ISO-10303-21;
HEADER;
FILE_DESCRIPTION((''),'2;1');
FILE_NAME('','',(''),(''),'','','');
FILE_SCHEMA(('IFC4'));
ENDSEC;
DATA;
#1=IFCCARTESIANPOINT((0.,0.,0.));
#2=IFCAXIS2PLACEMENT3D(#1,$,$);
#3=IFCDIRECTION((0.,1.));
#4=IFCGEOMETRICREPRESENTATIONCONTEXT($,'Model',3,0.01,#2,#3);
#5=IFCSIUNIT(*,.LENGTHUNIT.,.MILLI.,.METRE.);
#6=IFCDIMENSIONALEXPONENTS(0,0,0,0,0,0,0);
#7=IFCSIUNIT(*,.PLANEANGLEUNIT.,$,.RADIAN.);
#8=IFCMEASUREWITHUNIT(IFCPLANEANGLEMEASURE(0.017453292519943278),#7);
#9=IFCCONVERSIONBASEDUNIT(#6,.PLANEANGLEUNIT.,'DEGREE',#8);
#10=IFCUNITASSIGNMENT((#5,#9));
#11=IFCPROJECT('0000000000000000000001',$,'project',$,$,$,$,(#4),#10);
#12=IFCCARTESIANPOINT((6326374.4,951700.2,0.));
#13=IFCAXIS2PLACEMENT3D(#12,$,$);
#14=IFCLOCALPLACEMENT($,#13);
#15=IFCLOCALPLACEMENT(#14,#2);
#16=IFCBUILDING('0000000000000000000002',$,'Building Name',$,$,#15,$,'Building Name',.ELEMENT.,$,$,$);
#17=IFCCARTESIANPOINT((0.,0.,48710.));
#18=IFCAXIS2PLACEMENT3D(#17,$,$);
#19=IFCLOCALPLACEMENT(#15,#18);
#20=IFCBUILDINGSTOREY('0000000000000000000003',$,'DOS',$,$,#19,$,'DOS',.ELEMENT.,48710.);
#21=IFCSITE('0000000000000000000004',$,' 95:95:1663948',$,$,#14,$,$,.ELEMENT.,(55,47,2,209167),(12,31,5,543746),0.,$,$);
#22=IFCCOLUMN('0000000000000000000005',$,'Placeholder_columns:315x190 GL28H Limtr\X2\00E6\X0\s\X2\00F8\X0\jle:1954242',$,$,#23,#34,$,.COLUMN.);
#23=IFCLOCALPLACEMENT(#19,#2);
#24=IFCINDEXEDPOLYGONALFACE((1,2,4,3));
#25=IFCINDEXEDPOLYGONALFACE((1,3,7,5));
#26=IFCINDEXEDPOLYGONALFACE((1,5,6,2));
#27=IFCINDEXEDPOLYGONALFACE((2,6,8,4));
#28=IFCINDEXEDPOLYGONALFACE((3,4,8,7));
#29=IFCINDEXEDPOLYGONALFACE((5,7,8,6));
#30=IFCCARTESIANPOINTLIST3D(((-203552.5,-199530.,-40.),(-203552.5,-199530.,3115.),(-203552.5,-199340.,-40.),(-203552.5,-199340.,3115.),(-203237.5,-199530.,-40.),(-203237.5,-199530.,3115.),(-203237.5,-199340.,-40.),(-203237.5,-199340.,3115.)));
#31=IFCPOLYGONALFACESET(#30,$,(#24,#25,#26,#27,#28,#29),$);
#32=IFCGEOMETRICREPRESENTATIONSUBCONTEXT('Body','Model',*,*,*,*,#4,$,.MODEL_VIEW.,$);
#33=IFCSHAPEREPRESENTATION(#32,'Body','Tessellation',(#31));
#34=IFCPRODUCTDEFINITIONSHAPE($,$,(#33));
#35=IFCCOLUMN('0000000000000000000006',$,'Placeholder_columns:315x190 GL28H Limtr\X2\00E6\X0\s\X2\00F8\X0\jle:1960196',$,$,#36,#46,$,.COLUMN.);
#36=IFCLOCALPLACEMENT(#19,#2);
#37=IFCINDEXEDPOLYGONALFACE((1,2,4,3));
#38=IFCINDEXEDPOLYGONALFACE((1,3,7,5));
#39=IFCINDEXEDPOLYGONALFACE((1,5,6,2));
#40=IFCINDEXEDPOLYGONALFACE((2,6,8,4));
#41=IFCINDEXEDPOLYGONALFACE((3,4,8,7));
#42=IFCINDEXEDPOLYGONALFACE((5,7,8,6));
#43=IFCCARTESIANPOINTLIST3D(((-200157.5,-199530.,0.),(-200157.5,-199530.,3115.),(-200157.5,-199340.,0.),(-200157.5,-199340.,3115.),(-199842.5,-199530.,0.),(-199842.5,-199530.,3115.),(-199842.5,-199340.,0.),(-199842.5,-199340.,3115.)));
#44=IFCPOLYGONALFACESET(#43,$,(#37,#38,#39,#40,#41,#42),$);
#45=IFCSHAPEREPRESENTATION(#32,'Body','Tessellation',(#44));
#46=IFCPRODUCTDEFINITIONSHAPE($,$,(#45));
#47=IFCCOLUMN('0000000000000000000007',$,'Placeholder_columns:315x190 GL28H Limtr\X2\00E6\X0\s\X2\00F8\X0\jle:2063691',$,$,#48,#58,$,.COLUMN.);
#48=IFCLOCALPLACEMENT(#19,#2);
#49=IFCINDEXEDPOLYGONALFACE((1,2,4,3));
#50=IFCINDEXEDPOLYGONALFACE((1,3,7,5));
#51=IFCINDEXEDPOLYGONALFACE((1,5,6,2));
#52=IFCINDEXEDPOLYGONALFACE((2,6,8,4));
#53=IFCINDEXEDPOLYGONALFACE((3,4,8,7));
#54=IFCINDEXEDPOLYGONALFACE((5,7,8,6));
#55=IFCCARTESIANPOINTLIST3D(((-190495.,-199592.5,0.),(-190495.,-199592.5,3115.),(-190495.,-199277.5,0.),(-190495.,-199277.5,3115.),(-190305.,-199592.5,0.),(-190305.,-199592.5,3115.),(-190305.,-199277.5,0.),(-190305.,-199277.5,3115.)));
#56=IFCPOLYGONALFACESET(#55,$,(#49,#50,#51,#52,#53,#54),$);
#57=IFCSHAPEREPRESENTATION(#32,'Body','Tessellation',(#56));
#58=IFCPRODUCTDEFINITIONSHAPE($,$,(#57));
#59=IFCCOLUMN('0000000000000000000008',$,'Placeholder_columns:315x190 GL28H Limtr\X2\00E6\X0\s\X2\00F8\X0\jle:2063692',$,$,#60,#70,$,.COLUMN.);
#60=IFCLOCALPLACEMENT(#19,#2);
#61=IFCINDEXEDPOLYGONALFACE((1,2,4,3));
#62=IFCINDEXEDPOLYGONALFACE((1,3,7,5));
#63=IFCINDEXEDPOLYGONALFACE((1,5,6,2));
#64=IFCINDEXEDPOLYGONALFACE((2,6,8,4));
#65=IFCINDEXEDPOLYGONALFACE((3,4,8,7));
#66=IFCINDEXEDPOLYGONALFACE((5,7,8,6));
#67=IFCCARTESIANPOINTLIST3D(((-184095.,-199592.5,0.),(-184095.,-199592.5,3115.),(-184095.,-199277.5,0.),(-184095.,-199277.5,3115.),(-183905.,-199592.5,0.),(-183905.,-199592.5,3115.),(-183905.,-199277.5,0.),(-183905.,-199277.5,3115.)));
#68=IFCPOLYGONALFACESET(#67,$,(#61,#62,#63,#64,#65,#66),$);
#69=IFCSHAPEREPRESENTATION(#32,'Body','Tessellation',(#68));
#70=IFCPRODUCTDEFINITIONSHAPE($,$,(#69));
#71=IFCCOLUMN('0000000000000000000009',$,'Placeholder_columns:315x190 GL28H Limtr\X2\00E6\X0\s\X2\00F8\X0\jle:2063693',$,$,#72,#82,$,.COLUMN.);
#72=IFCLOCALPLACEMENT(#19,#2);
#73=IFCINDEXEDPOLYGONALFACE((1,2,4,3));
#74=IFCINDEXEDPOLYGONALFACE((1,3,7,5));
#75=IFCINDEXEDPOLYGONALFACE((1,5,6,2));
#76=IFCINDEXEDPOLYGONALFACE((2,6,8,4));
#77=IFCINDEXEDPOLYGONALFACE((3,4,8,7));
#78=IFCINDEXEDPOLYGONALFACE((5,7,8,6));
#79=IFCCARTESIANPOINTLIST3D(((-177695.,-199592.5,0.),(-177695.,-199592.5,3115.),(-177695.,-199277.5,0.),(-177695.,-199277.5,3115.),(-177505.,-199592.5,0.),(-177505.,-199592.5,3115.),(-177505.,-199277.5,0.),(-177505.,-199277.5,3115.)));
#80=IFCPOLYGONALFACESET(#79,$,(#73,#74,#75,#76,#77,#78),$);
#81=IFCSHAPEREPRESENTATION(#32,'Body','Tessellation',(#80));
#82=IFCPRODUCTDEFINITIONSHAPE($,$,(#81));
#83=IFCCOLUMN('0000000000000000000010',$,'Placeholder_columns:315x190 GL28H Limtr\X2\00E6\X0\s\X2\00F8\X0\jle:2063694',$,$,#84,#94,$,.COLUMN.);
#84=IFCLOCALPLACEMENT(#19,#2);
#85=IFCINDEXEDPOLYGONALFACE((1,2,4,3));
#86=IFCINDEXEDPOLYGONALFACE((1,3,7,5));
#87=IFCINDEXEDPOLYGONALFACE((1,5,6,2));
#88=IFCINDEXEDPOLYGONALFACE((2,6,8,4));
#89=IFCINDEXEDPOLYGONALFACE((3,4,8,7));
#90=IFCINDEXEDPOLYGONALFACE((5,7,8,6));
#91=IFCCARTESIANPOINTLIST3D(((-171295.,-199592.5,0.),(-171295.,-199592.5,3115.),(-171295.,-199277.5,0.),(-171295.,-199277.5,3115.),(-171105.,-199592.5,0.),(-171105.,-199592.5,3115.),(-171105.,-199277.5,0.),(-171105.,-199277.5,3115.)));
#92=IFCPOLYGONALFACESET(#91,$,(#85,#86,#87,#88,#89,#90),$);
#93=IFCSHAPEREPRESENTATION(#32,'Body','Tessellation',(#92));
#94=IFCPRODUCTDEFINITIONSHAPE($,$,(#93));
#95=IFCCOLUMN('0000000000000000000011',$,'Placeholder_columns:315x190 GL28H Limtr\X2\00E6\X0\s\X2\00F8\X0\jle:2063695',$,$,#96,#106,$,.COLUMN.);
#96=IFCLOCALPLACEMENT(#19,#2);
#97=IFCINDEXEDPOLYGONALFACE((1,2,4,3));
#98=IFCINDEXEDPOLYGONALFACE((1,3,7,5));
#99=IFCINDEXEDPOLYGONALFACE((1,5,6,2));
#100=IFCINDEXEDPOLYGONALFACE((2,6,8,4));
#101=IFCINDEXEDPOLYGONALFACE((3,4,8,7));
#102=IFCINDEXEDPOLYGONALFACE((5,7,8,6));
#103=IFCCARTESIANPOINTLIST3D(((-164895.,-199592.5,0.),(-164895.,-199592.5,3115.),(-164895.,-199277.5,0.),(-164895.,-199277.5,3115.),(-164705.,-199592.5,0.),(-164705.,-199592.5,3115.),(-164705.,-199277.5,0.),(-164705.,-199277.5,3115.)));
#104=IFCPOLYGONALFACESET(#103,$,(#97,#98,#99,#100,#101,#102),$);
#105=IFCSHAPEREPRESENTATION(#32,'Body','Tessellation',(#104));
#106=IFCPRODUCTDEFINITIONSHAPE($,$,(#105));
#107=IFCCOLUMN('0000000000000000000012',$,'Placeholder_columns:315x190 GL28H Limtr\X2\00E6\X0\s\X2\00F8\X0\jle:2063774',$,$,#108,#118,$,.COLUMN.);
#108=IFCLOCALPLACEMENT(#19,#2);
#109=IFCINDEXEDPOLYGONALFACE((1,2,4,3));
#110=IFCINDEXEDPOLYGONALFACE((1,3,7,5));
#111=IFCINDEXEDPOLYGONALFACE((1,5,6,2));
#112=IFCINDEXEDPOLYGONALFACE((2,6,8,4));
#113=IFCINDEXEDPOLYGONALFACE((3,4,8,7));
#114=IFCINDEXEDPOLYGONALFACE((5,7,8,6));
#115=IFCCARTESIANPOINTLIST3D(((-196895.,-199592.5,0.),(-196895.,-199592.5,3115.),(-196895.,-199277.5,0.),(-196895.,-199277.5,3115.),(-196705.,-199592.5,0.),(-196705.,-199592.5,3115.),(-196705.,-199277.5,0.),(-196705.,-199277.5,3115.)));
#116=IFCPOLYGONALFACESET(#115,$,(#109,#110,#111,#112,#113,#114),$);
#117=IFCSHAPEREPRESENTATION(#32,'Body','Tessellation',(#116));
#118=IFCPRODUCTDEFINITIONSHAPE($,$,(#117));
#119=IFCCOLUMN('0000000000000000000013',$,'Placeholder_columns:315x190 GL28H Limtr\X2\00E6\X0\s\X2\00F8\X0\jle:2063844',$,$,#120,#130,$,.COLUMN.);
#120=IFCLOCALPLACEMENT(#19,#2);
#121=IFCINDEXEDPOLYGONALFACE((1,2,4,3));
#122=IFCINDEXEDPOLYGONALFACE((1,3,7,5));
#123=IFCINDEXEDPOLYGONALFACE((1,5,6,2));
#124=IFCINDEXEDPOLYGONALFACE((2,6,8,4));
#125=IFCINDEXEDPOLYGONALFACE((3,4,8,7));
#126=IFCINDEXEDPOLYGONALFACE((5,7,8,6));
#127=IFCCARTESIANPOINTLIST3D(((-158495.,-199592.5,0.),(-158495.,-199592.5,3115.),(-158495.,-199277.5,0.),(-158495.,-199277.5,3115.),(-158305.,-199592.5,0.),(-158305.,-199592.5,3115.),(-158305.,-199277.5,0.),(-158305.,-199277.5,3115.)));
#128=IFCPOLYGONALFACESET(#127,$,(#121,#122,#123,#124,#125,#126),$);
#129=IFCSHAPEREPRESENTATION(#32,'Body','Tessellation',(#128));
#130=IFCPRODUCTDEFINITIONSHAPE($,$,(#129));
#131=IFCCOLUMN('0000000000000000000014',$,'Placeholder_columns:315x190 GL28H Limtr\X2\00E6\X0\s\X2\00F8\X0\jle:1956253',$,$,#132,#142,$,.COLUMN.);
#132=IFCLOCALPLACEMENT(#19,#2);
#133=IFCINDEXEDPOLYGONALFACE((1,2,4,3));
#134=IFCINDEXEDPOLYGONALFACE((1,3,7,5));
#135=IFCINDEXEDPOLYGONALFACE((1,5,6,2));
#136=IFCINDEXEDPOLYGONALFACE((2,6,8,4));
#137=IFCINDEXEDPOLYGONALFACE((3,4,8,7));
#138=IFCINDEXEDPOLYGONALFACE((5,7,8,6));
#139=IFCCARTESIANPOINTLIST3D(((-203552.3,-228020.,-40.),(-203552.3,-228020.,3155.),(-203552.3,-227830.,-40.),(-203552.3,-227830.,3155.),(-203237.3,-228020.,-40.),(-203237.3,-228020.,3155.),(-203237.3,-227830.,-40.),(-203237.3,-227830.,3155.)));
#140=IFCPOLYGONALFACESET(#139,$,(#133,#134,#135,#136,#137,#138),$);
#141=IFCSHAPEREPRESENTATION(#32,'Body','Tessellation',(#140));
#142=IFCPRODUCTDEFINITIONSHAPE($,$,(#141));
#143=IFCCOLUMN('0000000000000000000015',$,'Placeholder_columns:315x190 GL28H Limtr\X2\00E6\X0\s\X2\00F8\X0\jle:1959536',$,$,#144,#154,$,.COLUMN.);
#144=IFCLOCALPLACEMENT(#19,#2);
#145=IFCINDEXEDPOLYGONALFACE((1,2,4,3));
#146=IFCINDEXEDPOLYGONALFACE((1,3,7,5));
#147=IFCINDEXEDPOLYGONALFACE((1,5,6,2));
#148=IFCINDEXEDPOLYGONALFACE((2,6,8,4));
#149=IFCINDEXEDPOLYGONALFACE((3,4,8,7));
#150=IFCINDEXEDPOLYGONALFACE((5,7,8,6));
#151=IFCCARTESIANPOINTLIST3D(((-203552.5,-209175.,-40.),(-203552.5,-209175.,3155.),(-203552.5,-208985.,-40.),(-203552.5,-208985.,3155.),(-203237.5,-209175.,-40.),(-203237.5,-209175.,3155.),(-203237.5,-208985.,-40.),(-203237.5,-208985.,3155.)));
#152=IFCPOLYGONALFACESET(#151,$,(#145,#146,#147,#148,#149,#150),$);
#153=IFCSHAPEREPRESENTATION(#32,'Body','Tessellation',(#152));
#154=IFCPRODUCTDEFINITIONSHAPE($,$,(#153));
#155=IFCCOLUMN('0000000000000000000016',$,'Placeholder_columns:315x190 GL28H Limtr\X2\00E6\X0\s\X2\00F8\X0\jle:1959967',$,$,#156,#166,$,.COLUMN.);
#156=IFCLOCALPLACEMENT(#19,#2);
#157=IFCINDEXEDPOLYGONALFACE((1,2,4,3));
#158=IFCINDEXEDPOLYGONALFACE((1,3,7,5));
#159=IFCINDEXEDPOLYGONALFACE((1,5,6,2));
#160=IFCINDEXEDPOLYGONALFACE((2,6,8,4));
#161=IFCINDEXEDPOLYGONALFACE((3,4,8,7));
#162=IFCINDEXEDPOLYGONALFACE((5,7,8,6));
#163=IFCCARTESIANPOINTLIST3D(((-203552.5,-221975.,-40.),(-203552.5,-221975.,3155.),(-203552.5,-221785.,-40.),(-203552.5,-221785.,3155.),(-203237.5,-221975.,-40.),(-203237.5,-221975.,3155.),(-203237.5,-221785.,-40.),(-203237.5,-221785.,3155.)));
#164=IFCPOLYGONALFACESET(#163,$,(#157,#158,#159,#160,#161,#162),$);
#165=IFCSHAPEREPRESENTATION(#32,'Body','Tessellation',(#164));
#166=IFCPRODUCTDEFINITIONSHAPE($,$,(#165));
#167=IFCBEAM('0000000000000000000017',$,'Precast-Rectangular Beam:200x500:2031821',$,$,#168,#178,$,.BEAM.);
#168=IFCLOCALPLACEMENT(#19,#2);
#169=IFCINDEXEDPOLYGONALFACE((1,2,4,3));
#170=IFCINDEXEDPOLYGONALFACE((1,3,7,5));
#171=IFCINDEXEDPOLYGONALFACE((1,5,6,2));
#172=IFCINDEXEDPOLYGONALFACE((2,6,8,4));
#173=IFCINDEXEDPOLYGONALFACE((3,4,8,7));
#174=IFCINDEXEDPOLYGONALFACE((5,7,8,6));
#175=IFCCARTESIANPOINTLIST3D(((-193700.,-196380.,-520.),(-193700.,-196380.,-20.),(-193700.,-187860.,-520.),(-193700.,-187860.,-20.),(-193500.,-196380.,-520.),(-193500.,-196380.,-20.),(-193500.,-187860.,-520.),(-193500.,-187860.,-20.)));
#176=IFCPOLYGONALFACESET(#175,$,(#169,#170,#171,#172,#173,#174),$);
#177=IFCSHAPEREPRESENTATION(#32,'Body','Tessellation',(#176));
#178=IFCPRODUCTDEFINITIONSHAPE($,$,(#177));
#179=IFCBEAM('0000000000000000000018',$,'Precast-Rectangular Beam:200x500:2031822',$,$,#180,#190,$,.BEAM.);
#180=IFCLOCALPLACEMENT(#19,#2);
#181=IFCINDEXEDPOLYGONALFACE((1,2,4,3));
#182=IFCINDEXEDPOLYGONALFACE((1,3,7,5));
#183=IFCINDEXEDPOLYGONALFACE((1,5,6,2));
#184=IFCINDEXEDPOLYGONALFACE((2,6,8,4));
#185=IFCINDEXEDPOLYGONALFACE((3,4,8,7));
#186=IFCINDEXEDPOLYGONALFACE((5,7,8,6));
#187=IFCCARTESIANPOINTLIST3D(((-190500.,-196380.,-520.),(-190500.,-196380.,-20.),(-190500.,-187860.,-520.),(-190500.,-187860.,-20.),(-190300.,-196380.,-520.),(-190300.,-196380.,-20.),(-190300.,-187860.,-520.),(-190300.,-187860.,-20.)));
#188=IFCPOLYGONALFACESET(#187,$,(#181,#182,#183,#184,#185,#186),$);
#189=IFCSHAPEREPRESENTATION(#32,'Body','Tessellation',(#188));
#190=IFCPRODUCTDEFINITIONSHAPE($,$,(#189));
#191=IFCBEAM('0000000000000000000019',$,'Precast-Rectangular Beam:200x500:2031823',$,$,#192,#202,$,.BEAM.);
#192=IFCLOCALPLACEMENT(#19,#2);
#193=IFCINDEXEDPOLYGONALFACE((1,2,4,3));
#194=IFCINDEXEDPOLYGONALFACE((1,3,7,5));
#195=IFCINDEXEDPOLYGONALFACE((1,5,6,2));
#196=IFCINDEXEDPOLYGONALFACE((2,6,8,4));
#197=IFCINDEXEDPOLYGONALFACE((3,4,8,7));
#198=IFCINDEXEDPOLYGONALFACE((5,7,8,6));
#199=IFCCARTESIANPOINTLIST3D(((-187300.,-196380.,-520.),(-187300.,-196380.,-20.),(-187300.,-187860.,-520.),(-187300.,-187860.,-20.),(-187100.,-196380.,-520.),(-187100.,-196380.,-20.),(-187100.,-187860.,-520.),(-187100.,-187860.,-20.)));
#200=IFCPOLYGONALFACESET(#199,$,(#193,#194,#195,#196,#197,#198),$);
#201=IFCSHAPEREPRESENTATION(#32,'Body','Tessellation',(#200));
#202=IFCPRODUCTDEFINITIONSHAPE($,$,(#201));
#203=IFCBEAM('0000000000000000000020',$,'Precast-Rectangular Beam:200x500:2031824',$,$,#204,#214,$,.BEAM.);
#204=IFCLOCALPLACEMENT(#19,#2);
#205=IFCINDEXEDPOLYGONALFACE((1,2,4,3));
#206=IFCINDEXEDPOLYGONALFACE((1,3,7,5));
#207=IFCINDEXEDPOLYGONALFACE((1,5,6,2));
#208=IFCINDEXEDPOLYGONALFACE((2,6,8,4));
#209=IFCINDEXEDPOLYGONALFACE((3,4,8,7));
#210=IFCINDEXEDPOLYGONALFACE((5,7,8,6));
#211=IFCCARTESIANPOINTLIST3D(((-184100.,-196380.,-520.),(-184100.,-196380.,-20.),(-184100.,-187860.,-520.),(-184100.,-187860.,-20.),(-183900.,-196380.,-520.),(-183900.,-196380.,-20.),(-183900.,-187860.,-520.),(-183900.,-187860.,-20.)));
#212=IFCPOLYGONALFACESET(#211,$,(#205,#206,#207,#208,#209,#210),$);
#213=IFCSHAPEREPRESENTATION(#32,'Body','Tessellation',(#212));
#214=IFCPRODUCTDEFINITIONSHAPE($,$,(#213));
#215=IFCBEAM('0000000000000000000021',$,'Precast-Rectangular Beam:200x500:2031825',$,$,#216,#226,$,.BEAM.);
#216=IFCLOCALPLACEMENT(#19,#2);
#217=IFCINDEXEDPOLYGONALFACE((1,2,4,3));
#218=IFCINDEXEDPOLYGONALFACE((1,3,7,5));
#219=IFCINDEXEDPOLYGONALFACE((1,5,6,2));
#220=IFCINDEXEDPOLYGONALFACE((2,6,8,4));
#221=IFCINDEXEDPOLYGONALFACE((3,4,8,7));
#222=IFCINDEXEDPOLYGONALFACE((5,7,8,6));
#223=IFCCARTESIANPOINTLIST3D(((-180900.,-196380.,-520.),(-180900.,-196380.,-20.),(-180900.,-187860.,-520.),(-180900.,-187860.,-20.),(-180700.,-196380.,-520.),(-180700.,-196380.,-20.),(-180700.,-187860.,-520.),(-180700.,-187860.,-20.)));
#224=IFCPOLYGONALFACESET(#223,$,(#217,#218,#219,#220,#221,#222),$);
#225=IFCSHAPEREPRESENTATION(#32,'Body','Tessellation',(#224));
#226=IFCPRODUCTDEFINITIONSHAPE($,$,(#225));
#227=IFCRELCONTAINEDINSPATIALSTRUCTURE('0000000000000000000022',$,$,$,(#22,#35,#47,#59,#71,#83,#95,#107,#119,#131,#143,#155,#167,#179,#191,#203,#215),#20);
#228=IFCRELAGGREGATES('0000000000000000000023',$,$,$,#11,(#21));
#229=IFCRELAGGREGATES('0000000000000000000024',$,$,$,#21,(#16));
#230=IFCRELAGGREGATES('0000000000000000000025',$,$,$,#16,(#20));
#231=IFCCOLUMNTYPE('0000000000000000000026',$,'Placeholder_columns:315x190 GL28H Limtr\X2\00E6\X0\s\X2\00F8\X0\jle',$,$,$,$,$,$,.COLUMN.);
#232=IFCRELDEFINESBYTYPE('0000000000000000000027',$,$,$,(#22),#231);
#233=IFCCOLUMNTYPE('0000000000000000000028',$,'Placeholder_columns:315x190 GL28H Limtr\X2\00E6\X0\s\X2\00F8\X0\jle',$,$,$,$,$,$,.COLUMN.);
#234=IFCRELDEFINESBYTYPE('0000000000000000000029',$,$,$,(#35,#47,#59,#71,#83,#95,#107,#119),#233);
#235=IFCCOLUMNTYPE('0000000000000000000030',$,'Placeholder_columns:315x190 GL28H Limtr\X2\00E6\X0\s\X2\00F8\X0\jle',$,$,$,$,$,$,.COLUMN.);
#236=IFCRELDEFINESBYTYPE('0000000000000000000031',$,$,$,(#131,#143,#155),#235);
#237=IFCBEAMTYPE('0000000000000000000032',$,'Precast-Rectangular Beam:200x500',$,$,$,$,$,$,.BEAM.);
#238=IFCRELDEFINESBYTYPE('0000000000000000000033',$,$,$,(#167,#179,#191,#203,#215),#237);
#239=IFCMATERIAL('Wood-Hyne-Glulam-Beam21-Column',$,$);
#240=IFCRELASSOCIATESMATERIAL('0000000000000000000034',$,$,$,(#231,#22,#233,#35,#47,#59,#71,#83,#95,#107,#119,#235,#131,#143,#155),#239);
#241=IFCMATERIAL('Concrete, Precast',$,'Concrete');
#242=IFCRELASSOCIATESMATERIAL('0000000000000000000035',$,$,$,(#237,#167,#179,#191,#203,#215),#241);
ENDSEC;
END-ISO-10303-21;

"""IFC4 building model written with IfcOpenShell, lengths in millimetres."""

from ifc_helpers import new_model, entity, si_unit, converted_unit, direction, frame, origin, place, context, subcontext, project, spatial, indexed_curve, outline, extrude, source, transform, mapped, material, type_object, type_shapes, element, save


model = new_model("IFC4")

# Units and contexts
model_context = context("Model", 3, precision=0.01, world=origin(), true_north=direction((0.0, 1.0)))
body_context = subcontext(model_context, "Body", "Model", "MODEL_VIEW")
ifc_project = project(units=[si_unit("LENGTHUNIT", "METRE", prefix="MILLI"), converted_unit("PLANEANGLEUNIT", "DEGREE", entity("IfcPlaneAngleMeasure", 0.017453292519943278), si_unit("PLANEANGLEUNIT", "RADIAN"), dimensions=[0, 0, 0, 0, 0, 0, 0])], contexts=[model_context])

# Site, building, storey
site_placement = place(None, frame((6326374.4, 951700.2, 0.0)))
site = spatial("IfcSite", under=ifc_project, at=site_placement, Name=" 95:95:1663948", CompositionType="ELEMENT", RefLatitude=(55, 47, 2, 209167), RefLongitude=(12, 31, 5, 543746), RefElevation=0.0)
building_placement = place(site_placement, origin())
building = spatial("IfcBuilding", under=site, at=building_placement, Name="Building Name", LongName="Building Name", CompositionType="ELEMENT")
storey_placement = place(building_placement, frame((0.0, 0.0, 48710.0)))
storey = spatial("IfcBuildingStorey", under=building, at=storey_placement, Name="DOS", LongName="DOS", CompositionType="ELEMENT", Elevation=48710.0)

# Columns
ifc_material_1 = material(Name="Wood-Hyne-Glulam-Beam21-Column")
column_type_1 = type_object("IfcColumnType", Name="Placeholder_columns:315x190 GL28H Limtræsøjle", PredefinedType="COLUMN", material=ifc_material_1)
shared_shape_1 = source(origin(), body_context, "Body", "SweptSolid", [
    extrude(outline(indexed_curve([(-157.5, -95.0), (157.5, -95.0), (157.5, 95.0), (-157.5, 95.0), (-157.5, -95.0)], self_intersect=False)), frame((0.0, 0.0, 48670.0), z_axis=(0.0, 0.0, 1.0), x_axis=(-1.0, 0.0, 0.0)), (0.0, 0.0, 1.0), 3155.0),
])
type_shapes(column_type_1, [shared_shape_1])
column_1_placement = place(storey_placement, frame((-203395.0, -199435.0, -48710.0)))
element("IfcColumn", 1, at=column_1_placement, inside=storey, type_object=column_type_1, material=ifc_material_1, Name="Placeholder_columns:315x190 GL28H Limtræsøjle:1954242", PredefinedType="COLUMN", context=body_context, shape_type="MappedRepresentation", body=[
    mapped(shared_shape_1, transform((0.0, 0.0, 0.0), scale=1.0)),
])
column_type_2 = type_object("IfcColumnType", Name="Placeholder_columns:315x190 GL28H Limtræsøjle", PredefinedType="COLUMN", material=ifc_material_1)
shared_shape_2 = source(origin(), body_context, "Body", "SweptSolid", [
    extrude(outline(indexed_curve([(-157.5, -95.0), (157.5, -95.0), (157.5, 95.0), (-157.5, 95.0), (-157.5, -95.0)], self_intersect=False)), frame((0.0, 0.0, 48710.0), z_axis=(0.0, 0.0, 1.0), x_axis=(-1.0, 0.0, 0.0)), (0.0, 0.0, 1.0), 3115.0),
])
type_shapes(column_type_2, [shared_shape_2])
column_2_placement = place(storey_placement, frame((-200000.0, -199435.0, -48710.0)))
element("IfcColumn", 2, at=column_2_placement, inside=storey, type_object=column_type_2, material=ifc_material_1, Name="Placeholder_columns:315x190 GL28H Limtræsøjle:1960196", PredefinedType="COLUMN", context=body_context, shape_type="MappedRepresentation", body=[
    mapped(shared_shape_2, transform((0.0, 0.0, 0.0), scale=1.0)),
])
for number, where, z_axis, x_axis, name in (
    (3, (-190400.0, -199435.0, -48710.0), (0.0, 0.0, 1.0), (0.0, -1.0, 0.0), "Placeholder_columns:315x190 GL28H Limtræsøjle:2063691"),
    (4, (-184000.0, -199435.0, -48710.0), (0.0, 0.0, 1.0), (0.0, -1.0, 0.0), "Placeholder_columns:315x190 GL28H Limtræsøjle:2063692"),
    (5, (-177600.0, -199435.0, -48710.0), (0.0, 0.0, 1.0), (0.0, -1.0, 0.0), "Placeholder_columns:315x190 GL28H Limtræsøjle:2063693"),
    (6, (-171200.0, -199435.0, -48710.0), (0.0, 0.0, 1.0), (0.0, -1.0, 0.0), "Placeholder_columns:315x190 GL28H Limtræsøjle:2063694"),
    (7, (-164800.0, -199435.0, -48710.0), (0.0, 0.0, 1.0), (0.0, -1.0, 0.0), "Placeholder_columns:315x190 GL28H Limtræsøjle:2063695"),
    (8, (-196800.0, -199435.0, -48710.0), (0.0, 0.0, 1.0), (0.0, -1.0, 0.0), "Placeholder_columns:315x190 GL28H Limtræsøjle:2063774"),
    (9, (-158400.0, -199435.0, -48710.0), (0.0, 0.0, 1.0), (0.0, -1.0, 0.0), "Placeholder_columns:315x190 GL28H Limtræsøjle:2063844"),
):
    element("IfcColumn", number, at=place(storey_placement, frame(where, z_axis=z_axis, x_axis=x_axis)), inside=storey, type_object=column_type_2, material=ifc_material_1, Name=name, PredefinedType="COLUMN", context=body_context, shape_type="MappedRepresentation", body=[
        mapped(shared_shape_2, transform((0.0, 0.0, 0.0), scale=1.0)),
    ])
column_type_3 = type_object("IfcColumnType", Name="Placeholder_columns:315x190 GL28H Limtræsøjle", PredefinedType="COLUMN", material=ifc_material_1)
shared_shape_3 = source(origin(), body_context, "Body", "SweptSolid", [
    extrude(outline(indexed_curve([(-157.5, -95.0), (157.5, -95.0), (157.5, 95.0), (-157.5, 95.0), (-157.5, -95.0)], self_intersect=False)), frame((0.0, 0.0, 48670.0), z_axis=(0.0, 0.0, 1.0), x_axis=(-1.0, 0.0, 0.0)), (0.0, 0.0, 1.0), 3195.0),
])
type_shapes(column_type_3, [shared_shape_3])
for number, where, name in (
    (10, (-203394.8, -227925.0, -48710.0), "Placeholder_columns:315x190 GL28H Limtræsøjle:1956253"),
    (11, (-203395.0, -209080.0, -48710.0), "Placeholder_columns:315x190 GL28H Limtræsøjle:1959536"),
    (12, (-203395.0, -221880.0, -48710.0), "Placeholder_columns:315x190 GL28H Limtræsøjle:1959967"),
):
    element("IfcColumn", number, at=place(storey_placement, frame(where)), inside=storey, type_object=column_type_3, material=ifc_material_1, Name=name, PredefinedType="COLUMN", context=body_context, shape_type="MappedRepresentation", body=[
        mapped(shared_shape_3, transform((0.0, 0.0, 0.0), scale=1.0)),
    ])

# Beams
ifc_material_2 = material(Name="Concrete, Precast", Category="Concrete")
beam_type_1 = type_object("IfcBeamType", Name="Precast-Rectangular Beam:200x500", PredefinedType="BEAM", material=ifc_material_2)
shared_shape_4 = source(origin(), body_context, "Body", "SweptSolid", [
    extrude(outline(indexed_curve([(-4260.0, -100.0), (4260.0, -100.0), (4260.0, 100.0), (-4260.0, 100.0), (-4260.0, -100.0)], self_intersect=False)), frame((3.6, 0.0, -250.0), z_axis=(0.0, 0.0, 1.0), x_axis=(-1.0, 0.0, 0.0)), (0.0, 0.0, 1.0), 500.0),
])
type_shapes(beam_type_1, [shared_shape_4])
for number, where, z_axis, x_axis, name in (
    (13, (-193600.0, -192116.4, -270.0), (0.0, 0.0, 1.0), (0.0, -1.0, 0.0), "Precast-Rectangular Beam:200x500:2031821"),
    (14, (-190400.0, -192116.4, -270.0), (0.0, 0.0, 1.0), (0.0, -1.0, 0.0), "Precast-Rectangular Beam:200x500:2031822"),
    (15, (-187200.0, -192116.4, -270.0), (0.0, 0.0, 1.0), (0.0, -1.0, 0.0), "Precast-Rectangular Beam:200x500:2031823"),
    (16, (-184000.0, -192116.4, -270.0), (0.0, 0.0, 1.0), (0.0, -1.0, 0.0), "Precast-Rectangular Beam:200x500:2031824"),
    (17, (-180800.0, -192116.4, -270.0), (0.0, 0.0, 1.0), (0.0, -1.0, 0.0), "Precast-Rectangular Beam:200x500:2031825"),
):
    element("IfcBeam", number, at=place(storey_placement, frame(where, z_axis=z_axis, x_axis=x_axis)), inside=storey, type_object=beam_type_1, material=ifc_material_2, Name=name, PredefinedType="BEAM", context=body_context, shape_type="MappedRepresentation", body=[
        mapped(shared_shape_4, transform((0.0, 0.0, 0.0), scale=1.0)),
    ])

save(model, "model.ifc")
